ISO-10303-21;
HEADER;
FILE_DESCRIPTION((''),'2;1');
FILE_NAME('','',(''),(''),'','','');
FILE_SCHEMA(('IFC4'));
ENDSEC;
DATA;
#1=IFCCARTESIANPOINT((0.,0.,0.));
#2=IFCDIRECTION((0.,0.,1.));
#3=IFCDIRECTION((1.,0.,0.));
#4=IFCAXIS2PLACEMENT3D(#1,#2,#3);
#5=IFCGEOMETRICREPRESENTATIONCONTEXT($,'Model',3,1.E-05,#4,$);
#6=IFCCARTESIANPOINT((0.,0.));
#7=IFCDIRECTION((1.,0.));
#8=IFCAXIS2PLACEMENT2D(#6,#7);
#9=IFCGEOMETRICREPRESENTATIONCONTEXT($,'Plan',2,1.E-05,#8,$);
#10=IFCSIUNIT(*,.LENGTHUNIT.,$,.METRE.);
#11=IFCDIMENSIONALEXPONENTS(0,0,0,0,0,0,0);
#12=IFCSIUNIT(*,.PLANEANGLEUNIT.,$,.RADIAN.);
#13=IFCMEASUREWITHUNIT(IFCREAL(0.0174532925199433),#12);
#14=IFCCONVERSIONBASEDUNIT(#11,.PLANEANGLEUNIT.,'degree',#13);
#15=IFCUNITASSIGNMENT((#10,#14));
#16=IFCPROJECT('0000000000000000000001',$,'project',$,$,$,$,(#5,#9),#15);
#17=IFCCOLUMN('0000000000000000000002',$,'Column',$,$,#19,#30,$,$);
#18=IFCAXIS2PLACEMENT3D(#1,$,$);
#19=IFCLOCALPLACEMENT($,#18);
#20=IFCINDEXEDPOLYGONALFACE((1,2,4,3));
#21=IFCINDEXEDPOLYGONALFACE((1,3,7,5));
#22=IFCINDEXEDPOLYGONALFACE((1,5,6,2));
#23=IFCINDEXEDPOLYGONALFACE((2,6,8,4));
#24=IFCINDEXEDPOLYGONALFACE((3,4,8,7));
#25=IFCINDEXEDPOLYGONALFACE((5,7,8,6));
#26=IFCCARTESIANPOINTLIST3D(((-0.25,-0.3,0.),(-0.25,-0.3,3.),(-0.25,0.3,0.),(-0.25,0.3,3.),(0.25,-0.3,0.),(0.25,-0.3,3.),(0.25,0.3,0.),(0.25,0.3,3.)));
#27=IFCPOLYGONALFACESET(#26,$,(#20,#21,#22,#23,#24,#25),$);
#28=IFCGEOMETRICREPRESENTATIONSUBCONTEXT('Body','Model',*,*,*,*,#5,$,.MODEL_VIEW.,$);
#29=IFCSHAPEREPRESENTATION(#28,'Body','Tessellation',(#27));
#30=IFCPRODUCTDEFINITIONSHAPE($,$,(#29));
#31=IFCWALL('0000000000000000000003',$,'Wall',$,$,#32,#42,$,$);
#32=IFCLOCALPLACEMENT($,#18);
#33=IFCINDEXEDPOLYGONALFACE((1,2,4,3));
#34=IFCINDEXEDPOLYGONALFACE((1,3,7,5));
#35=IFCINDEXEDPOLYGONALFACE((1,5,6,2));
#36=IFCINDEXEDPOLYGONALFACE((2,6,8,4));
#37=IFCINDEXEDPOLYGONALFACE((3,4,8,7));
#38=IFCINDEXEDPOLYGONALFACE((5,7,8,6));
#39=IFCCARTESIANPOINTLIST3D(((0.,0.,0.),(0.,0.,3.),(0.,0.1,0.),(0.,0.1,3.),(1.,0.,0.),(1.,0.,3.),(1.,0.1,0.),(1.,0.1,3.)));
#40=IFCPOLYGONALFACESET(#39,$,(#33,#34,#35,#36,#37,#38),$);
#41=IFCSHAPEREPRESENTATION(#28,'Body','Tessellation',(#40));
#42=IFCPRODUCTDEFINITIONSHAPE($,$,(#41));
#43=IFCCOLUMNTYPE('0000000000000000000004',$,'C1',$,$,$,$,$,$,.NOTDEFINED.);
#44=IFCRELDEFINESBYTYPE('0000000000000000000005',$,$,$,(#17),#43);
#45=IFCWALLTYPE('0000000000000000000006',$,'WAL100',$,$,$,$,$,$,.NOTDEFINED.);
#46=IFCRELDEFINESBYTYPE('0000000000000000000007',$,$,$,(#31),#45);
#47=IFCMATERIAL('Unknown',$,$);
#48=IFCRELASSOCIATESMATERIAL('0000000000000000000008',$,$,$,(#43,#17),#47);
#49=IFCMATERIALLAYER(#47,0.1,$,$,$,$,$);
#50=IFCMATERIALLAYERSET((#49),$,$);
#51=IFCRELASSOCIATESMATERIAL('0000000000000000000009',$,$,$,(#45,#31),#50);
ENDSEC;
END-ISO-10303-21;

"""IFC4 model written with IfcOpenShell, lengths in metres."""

from ifc_helpers import new_model, entity, si_unit, converted_unit, origin_with_axes, origin_2d_with_axis, place, context, subcontext, project, indexed_curve, rectangle, outline, extrude, material, layer, layer_set, layer_usage, material_profile, profile_set, profile_usage, type_object, element, save


model = new_model("IFC4")

# Units and contexts
model_context = context("Model", 3, precision=1e-05, world=origin_with_axes())
plan_context = context("Plan", 2, precision=1e-05, world=origin_2d_with_axis())
body_context = subcontext(model_context, "Body", "Model", "MODEL_VIEW")
ifc_project = project(units=[si_unit("LENGTHUNIT", "METRE"), converted_unit("PLANEANGLEUNIT", "degree", entity("IfcReal", 0.0174532925199433), si_unit("PLANEANGLEUNIT", "RADIAN"), dimensions=[0, 0, 0, 0, 0, 0, 0])], contexts=[model_context, plan_context])

# Column
ifc_material = material(Name="Unknown")
ifc_material_profile = material_profile(ifc_material, rectangle(XDim=0.5, YDim=0.6))
ifc_profile_set = profile_set([ifc_material_profile])
ifc_profile_usage = profile_usage(ifc_profile_set, cardinal=5)
column_type = type_object("IfcColumnType", Name="C1", PredefinedType="NOTDEFINED", material=ifc_profile_set)
column_placement = place(None, origin_with_axes())
element("IfcColumn", 1, at=column_placement, type_object=column_type, material=ifc_profile_usage, Name="Column", context=body_context, shape_type="SweptSolid", body=[
    extrude(rectangle(XDim=0.5, YDim=0.6), origin_with_axes(), (0.0, 0.0, 1.0), 3.0),
])

# Wall
ifc_layer = layer(ifc_material, 0.1)
ifc_layer_set = layer_set([ifc_layer])
ifc_layer_usage_1 = layer_usage(ifc_layer_set, "AXIS2", "POSITIVE", 0.0)
wall_type = type_object("IfcWallType", Name="WAL100", PredefinedType="NOTDEFINED", material=ifc_layer_set)
wall_1_placement = place(None, origin_with_axes())
element("IfcWall", 2, at=wall_1_placement, type_object=wall_type, material=ifc_layer_usage_1, Name="Wall", context=body_context, shape_type="SweptSolid", body=[
    extrude(outline(indexed_curve([(0.0, 0.0), (0.0, 0.1), (1.0, 0.1), (1.0, 0.0), (0.0, 0.0)], self_intersect=False)), origin_with_axes(), (0.0, 0.0, 1.0), 3.0),
])

save(model, "model.ifc")
